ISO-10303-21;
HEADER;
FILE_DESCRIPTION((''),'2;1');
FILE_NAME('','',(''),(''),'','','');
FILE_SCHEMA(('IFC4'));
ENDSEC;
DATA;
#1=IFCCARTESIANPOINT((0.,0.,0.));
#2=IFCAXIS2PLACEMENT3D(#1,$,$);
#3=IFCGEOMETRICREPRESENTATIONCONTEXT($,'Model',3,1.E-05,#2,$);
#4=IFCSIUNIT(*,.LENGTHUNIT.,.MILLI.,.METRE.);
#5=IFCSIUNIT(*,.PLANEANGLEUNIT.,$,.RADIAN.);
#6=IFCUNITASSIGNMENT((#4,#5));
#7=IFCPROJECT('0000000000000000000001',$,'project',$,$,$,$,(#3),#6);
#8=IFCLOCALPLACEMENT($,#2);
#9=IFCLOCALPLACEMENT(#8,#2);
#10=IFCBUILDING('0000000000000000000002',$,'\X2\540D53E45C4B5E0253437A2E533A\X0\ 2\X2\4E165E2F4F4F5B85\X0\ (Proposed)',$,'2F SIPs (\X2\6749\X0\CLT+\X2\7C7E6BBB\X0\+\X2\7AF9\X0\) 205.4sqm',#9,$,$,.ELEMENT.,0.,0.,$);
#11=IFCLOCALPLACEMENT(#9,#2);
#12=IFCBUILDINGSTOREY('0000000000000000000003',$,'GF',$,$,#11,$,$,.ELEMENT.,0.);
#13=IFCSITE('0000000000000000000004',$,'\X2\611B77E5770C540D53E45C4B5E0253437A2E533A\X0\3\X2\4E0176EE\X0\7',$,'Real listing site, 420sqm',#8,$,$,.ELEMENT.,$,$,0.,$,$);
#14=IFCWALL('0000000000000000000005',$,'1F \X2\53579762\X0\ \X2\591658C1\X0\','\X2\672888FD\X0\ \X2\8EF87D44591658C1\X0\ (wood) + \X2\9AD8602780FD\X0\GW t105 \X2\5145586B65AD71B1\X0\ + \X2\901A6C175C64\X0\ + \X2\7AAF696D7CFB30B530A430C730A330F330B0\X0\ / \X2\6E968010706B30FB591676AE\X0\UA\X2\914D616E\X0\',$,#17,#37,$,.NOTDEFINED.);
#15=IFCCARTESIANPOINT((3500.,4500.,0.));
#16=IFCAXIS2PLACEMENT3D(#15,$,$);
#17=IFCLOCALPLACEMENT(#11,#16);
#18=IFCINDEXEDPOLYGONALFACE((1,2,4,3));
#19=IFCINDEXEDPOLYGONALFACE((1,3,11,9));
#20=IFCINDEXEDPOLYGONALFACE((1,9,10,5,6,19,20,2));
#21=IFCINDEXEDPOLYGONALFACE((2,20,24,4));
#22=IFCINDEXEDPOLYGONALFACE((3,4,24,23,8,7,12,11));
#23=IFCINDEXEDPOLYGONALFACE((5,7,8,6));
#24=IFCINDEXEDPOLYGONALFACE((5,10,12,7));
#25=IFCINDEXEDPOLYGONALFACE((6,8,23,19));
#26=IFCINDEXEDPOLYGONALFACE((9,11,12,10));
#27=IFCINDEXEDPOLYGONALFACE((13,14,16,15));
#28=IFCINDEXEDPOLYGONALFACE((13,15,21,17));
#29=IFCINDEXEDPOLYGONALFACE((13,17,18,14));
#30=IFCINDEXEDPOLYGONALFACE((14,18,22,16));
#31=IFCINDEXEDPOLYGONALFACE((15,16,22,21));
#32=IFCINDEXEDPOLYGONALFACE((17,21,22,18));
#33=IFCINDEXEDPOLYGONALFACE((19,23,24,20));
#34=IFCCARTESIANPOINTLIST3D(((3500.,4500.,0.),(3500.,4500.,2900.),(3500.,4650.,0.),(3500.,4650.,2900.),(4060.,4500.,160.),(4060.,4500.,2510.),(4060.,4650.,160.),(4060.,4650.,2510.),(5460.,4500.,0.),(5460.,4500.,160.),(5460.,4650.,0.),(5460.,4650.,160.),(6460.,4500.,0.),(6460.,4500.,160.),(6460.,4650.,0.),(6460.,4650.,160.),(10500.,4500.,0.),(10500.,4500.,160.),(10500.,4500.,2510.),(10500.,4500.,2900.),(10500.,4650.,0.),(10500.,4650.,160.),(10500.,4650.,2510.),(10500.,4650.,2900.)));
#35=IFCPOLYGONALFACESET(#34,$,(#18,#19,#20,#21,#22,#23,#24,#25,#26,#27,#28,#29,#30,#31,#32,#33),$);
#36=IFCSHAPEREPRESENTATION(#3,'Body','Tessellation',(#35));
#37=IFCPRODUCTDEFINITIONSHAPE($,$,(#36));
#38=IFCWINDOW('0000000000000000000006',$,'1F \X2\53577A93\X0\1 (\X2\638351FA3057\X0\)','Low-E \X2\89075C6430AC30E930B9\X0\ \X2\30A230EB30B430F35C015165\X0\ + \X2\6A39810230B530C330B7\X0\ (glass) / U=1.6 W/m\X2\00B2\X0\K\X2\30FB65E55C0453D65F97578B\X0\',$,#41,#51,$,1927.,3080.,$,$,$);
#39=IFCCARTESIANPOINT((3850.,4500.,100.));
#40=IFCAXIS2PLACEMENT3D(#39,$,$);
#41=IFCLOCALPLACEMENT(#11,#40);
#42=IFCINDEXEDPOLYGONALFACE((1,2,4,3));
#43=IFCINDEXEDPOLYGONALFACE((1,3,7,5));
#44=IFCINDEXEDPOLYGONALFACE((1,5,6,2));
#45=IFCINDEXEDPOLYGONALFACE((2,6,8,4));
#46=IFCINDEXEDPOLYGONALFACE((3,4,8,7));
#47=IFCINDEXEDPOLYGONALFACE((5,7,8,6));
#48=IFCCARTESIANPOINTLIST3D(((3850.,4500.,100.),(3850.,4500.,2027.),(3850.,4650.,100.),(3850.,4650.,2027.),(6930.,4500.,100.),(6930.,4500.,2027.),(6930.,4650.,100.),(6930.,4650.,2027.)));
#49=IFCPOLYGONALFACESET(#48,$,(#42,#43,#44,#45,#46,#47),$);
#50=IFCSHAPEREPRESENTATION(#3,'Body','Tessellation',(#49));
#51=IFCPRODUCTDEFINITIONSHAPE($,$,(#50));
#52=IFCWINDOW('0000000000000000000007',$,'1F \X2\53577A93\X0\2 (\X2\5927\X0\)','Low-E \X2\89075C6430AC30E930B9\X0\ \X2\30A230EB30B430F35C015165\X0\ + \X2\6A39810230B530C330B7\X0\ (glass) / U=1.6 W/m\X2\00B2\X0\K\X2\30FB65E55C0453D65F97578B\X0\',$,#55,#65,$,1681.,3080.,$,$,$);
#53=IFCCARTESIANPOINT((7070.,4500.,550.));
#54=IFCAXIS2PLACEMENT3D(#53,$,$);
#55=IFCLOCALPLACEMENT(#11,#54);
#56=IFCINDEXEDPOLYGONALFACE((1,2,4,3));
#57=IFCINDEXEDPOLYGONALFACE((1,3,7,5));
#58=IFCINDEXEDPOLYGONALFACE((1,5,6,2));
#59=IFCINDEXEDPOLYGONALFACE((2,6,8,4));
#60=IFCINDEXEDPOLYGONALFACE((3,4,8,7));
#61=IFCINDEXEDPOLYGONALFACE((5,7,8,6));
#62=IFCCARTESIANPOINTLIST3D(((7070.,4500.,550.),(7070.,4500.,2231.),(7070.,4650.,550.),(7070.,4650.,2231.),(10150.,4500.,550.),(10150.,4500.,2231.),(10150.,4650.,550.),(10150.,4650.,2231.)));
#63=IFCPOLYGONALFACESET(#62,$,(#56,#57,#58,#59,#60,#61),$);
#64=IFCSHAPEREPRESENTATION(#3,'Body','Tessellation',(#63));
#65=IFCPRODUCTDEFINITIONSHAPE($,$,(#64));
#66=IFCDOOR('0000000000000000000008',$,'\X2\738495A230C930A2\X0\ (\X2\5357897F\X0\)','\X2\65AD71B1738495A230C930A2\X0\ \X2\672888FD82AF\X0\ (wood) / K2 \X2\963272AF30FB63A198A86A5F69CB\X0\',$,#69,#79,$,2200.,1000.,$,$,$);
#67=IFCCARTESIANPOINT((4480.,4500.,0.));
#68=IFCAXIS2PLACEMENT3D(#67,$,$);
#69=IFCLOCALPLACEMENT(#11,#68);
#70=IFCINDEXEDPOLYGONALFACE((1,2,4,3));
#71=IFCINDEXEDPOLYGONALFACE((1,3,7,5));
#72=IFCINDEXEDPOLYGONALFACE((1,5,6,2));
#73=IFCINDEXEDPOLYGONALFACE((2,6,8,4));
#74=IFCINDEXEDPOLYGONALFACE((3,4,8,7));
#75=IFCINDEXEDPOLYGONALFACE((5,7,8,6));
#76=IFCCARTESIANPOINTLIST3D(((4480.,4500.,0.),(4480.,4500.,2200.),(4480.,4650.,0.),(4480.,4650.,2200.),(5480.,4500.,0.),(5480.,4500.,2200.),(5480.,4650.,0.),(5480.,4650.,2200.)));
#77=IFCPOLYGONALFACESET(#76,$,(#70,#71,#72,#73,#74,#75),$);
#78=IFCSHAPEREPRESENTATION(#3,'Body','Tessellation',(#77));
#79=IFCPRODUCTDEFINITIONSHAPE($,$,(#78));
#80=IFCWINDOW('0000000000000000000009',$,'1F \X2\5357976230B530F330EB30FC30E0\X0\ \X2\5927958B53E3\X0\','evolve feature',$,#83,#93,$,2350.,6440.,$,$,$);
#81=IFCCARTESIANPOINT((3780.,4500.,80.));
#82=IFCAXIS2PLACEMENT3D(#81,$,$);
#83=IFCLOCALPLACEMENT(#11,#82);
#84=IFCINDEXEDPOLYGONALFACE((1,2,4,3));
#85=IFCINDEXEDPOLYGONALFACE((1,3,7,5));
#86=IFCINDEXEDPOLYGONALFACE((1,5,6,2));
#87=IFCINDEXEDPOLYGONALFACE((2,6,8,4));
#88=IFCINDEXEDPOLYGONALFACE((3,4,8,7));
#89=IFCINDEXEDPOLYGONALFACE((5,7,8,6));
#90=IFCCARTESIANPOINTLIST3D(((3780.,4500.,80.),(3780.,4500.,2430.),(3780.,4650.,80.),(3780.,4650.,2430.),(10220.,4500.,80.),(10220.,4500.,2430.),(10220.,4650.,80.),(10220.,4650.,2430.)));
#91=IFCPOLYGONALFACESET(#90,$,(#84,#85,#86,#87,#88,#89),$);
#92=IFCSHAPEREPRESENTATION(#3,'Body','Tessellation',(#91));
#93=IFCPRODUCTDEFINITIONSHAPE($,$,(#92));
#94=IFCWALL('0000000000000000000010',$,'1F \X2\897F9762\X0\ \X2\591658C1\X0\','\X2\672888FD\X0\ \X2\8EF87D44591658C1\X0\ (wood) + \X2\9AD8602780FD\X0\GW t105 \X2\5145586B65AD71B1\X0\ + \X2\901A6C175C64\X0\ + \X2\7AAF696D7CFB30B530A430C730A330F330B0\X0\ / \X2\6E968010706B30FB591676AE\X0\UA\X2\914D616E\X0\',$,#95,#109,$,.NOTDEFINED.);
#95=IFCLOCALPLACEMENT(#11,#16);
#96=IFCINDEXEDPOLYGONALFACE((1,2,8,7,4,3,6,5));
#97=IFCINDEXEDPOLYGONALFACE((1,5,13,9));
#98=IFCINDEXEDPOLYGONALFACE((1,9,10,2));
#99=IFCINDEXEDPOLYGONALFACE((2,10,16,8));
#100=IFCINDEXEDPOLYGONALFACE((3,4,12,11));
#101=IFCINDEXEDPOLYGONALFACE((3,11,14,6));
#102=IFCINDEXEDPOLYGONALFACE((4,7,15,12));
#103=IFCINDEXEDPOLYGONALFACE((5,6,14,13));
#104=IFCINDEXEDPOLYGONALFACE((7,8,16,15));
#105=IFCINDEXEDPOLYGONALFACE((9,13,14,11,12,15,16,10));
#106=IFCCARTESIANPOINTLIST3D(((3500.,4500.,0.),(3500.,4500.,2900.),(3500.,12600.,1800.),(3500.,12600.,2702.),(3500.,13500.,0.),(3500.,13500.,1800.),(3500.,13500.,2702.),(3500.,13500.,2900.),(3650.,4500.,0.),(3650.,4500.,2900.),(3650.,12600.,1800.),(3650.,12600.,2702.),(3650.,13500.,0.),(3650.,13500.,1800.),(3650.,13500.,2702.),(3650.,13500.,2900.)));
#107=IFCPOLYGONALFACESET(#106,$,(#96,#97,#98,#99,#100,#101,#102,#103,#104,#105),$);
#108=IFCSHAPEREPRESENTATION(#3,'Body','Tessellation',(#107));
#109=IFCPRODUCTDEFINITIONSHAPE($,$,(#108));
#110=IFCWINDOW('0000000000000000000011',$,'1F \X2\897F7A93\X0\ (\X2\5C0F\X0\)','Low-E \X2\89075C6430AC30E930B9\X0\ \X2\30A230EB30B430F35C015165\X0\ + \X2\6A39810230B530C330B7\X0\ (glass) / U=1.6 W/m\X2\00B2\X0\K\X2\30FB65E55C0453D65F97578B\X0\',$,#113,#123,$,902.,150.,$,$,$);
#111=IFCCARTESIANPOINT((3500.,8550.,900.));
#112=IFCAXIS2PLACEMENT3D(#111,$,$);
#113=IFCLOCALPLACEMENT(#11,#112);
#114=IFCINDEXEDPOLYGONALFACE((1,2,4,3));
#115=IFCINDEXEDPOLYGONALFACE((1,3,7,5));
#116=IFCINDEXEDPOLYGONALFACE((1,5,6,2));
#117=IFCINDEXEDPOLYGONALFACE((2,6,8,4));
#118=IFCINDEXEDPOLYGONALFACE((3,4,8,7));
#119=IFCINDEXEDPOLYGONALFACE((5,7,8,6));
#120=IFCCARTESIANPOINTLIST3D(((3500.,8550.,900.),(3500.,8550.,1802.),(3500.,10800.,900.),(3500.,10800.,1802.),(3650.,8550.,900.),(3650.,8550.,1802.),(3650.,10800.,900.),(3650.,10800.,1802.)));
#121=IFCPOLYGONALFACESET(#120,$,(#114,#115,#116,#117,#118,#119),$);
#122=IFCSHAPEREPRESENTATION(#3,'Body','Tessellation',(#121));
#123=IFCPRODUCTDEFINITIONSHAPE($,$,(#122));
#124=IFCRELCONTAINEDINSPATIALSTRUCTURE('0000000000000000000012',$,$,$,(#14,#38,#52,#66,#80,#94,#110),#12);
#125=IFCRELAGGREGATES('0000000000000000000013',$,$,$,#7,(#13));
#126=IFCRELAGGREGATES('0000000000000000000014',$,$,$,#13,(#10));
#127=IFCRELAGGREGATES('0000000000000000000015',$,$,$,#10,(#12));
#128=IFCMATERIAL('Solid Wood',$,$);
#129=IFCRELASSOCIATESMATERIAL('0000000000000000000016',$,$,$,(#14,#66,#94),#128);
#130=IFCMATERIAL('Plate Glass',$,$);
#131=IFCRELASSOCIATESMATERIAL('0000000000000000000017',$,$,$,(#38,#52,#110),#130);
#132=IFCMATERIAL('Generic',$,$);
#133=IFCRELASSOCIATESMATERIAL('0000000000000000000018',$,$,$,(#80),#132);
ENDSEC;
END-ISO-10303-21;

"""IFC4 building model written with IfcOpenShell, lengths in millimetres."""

from ifc_helpers import new_model, si_unit, frame, frame_2d, origin, place, context, project, spatial, rectangle, extrude, material, element, fill, save


model = new_model("IFC4")

# Units and contexts
model_context = context("Model", 3, precision=1e-05, world=origin())
ifc_project = project(units=[si_unit("LENGTHUNIT", "METRE", prefix="MILLI"), si_unit("PLANEANGLEUNIT", "RADIAN")], contexts=[model_context])

# Site, building, storey
site_placement = place(None, origin())
site = spatial("IfcSite", under=ifc_project, at=site_placement, Name="愛知県名古屋市千種区3丁目7", ObjectType="Real listing site, 420sqm", CompositionType="ELEMENT", RefElevation=0.0)
building_placement = place(site_placement, origin())
building = spatial("IfcBuilding", under=site, at=building_placement, Name="名古屋市千種区 2世帯住宅 (Proposed)", ObjectType="2F SIPs (杉CLT+籾殻+竹) 205.4sqm", CompositionType="ELEMENT", ElevationOfRefHeight=0.0, ElevationOfTerrain=0.0)
storey_placement = place(building_placement, origin())
storey = spatial("IfcBuildingStorey", under=building, at=storey_placement, Name="GF", CompositionType="ELEMENT", Elevation=0.0)

# Shared definitions
ifc_material_1 = material(Name="Solid Wood")

# Wall, openings, windows, door
wall_1_placement = place(storey_placement, frame((3500.0, 4500.0, 0.0)))
wall_1 = element("IfcWall", 1, at=wall_1_placement, inside=storey, material=ifc_material_1, Name="1F 南面 外壁", Description="木製 軸組外壁 (wood) + 高性能GW t105 充填断熱 + 通気層 + 窯業系サイディング / 準耐火・外皮UA配慮", PredefinedType="NOTDEFINED", context=model_context, shape_type="SweptSolid", body=[
    extrude(rectangle(XDim=7000.0, YDim=150.0, at=frame_2d((3500.0, 75.0))), frame((3500.0, 4500.0, 0.0)), (0.0, 0.0, 1.0), 2900.0),
])
opening_1_placement = place(storey_placement, frame((3850.0, 4500.0, 100.0)))
opening_1 = element("IfcOpeningElement", 2, at=opening_1_placement, cuts=wall_1, PredefinedType="NOTDEFINED", context=model_context, shape_type="SweptSolid", body=[
    extrude(rectangle(XDim=3080.0, YDim=150.0, at=frame_2d((1540.0, 75.0))), frame((3850.0, 4500.0, 100.0)), (0.0, 0.0, 1.0), 1927.0),
])
opening_2_placement = place(storey_placement, frame((7070.0, 4500.0, 550.0)))
opening_2 = element("IfcOpeningElement", 3, at=opening_2_placement, cuts=wall_1, PredefinedType="NOTDEFINED", context=model_context, shape_type="SweptSolid", body=[
    extrude(rectangle(XDim=3080.0, YDim=150.0, at=frame_2d((1540.0, 75.0))), frame((7070.0, 4500.0, 550.0)), (0.0, 0.0, 1.0), 1681.0),
])
opening_3_placement = place(storey_placement, frame((4480.0, 4500.0, 0.0)))
opening_3 = element("IfcOpeningElement", 4, at=opening_3_placement, cuts=wall_1, PredefinedType="NOTDEFINED", context=model_context, shape_type="SweptSolid", body=[
    extrude(rectangle(XDim=1000.0, YDim=150.0, at=frame_2d((500.0, 75.0))), frame((4480.0, 4500.0, 0.0)), (0.0, 0.0, 1.0), 2200.0),
])
opening_4_placement = place(storey_placement, frame((3780.0, 4500.0, 80.0)))
opening_4 = element("IfcOpeningElement", 5, at=opening_4_placement, cuts=wall_1, PredefinedType="NOTDEFINED", context=model_context, shape_type="SweptSolid", body=[
    extrude(rectangle(XDim=6440.0, YDim=150.0, at=frame_2d((3220.0, 75.0))), frame((3780.0, 4500.0, 80.0)), (0.0, 0.0, 1.0), 2350.0),
])
ifc_material_2 = material(Name="Plate Glass")
window_1_placement = place(storey_placement, frame((3850.0, 4500.0, 100.0)))
window_1 = element("IfcWindow", 6, at=window_1_placement, inside=storey, material=ifc_material_2, Name="1F 南窓1 (掃出し)", Description="Low-E 複層ガラス アルゴン封入 + 樹脂サッシ (glass) / U=1.6 W/m²K・日射取得型", OverallHeight=1927.0, OverallWidth=3080.0, context=model_context, shape_type="SweptSolid", body=[
    extrude(rectangle(XDim=3080.0, YDim=150.0, at=frame_2d((1540.0, 75.0))), frame((3850.0, 4500.0, 100.0)), (0.0, 0.0, 1.0), 1927.0),
])
fill(opening_1, window_1)
window_2_placement = place(storey_placement, frame((7070.0, 4500.0, 550.0)))
window_2 = element("IfcWindow", 7, at=window_2_placement, inside=storey, material=ifc_material_2, Name="1F 南窓2 (大)", Description="Low-E 複層ガラス アルゴン封入 + 樹脂サッシ (glass) / U=1.6 W/m²K・日射取得型", OverallHeight=1681.0, OverallWidth=3080.0, context=model_context, shape_type="SweptSolid", body=[
    extrude(rectangle(XDim=3080.0, YDim=150.0, at=frame_2d((1540.0, 75.0))), frame((7070.0, 4500.0, 550.0)), (0.0, 0.0, 1.0), 1681.0),
])
fill(opening_2, window_2)
door_placement = place(storey_placement, frame((4480.0, 4500.0, 0.0)))
door = element("IfcDoor", 8, at=door_placement, inside=storey, material=ifc_material_1, Name="玄関ドア (南西)", Description="断熱玄関ドア 木製芯 (wood) / K2 防犯・採風機構", OverallHeight=2200.0, OverallWidth=1000.0, context=model_context, shape_type="SweptSolid", body=[
    extrude(rectangle(XDim=1000.0, YDim=150.0, at=frame_2d((500.0, 75.0))), frame((4480.0, 4500.0, 0.0)), (0.0, 0.0, 1.0), 2200.0),
])
fill(opening_3, door)
ifc_material_3 = material(Name="Generic")
window_3_placement = place(storey_placement, frame((3780.0, 4500.0, 80.0)))
window_3 = element("IfcWindow", 9, at=window_3_placement, inside=storey, material=ifc_material_3, Name="1F 南面サンルーム 大開口", Description="evolve feature", OverallHeight=2350.0, OverallWidth=6440.0, context=model_context, shape_type="SweptSolid", body=[
    extrude(rectangle(XDim=6440.0, YDim=150.0, at=frame_2d((3220.0, 75.0))), frame((3780.0, 4500.0, 80.0)), (0.0, 0.0, 1.0), 2350.0),
])
fill(opening_4, window_3)

# Wall, opening, window
wall_2_placement = place(storey_placement, frame((3500.0, 4500.0, 0.0)))
wall_2 = element("IfcWall", 10, at=wall_2_placement, inside=storey, material=ifc_material_1, Name="1F 西面 外壁", Description="木製 軸組外壁 (wood) + 高性能GW t105 充填断熱 + 通気層 + 窯業系サイディング / 準耐火・外皮UA配慮", PredefinedType="NOTDEFINED", context=model_context, shape_type="SweptSolid", body=[
    extrude(rectangle(XDim=150.0, YDim=9000.0, at=frame_2d((75.0, 4500.0))), frame((3500.0, 4500.0, 0.0)), (0.0, 0.0, 1.0), 2900.0),
])
opening_5_placement = place(storey_placement, frame((3500.0, 8550.0, 900.0)))
opening_5 = element("IfcOpeningElement", 11, at=opening_5_placement, cuts=wall_2, PredefinedType="NOTDEFINED", context=model_context, shape_type="SweptSolid", body=[
    extrude(rectangle(XDim=150.0, YDim=2250.0, at=frame_2d((75.0, 1125.0))), frame((3500.0, 8550.0, 900.0)), (0.0, 0.0, 1.0), 902.0),
])
window_4_placement = place(storey_placement, frame((3500.0, 8550.0, 900.0)))
window_4 = element("IfcWindow", 12, at=window_4_placement, inside=storey, material=ifc_material_2, Name="1F 西窓 (小)", Description="Low-E 複層ガラス アルゴン封入 + 樹脂サッシ (glass) / U=1.6 W/m²K・日射取得型", OverallHeight=902.0, OverallWidth=150.0, context=model_context, shape_type="SweptSolid", body=[
    extrude(rectangle(XDim=150.0, YDim=2250.0, at=frame_2d((75.0, 1125.0))), frame((3500.0, 8550.0, 900.0)), (0.0, 0.0, 1.0), 902.0),
])
fill(opening_5, window_4)

save(model, "model.ifc")
